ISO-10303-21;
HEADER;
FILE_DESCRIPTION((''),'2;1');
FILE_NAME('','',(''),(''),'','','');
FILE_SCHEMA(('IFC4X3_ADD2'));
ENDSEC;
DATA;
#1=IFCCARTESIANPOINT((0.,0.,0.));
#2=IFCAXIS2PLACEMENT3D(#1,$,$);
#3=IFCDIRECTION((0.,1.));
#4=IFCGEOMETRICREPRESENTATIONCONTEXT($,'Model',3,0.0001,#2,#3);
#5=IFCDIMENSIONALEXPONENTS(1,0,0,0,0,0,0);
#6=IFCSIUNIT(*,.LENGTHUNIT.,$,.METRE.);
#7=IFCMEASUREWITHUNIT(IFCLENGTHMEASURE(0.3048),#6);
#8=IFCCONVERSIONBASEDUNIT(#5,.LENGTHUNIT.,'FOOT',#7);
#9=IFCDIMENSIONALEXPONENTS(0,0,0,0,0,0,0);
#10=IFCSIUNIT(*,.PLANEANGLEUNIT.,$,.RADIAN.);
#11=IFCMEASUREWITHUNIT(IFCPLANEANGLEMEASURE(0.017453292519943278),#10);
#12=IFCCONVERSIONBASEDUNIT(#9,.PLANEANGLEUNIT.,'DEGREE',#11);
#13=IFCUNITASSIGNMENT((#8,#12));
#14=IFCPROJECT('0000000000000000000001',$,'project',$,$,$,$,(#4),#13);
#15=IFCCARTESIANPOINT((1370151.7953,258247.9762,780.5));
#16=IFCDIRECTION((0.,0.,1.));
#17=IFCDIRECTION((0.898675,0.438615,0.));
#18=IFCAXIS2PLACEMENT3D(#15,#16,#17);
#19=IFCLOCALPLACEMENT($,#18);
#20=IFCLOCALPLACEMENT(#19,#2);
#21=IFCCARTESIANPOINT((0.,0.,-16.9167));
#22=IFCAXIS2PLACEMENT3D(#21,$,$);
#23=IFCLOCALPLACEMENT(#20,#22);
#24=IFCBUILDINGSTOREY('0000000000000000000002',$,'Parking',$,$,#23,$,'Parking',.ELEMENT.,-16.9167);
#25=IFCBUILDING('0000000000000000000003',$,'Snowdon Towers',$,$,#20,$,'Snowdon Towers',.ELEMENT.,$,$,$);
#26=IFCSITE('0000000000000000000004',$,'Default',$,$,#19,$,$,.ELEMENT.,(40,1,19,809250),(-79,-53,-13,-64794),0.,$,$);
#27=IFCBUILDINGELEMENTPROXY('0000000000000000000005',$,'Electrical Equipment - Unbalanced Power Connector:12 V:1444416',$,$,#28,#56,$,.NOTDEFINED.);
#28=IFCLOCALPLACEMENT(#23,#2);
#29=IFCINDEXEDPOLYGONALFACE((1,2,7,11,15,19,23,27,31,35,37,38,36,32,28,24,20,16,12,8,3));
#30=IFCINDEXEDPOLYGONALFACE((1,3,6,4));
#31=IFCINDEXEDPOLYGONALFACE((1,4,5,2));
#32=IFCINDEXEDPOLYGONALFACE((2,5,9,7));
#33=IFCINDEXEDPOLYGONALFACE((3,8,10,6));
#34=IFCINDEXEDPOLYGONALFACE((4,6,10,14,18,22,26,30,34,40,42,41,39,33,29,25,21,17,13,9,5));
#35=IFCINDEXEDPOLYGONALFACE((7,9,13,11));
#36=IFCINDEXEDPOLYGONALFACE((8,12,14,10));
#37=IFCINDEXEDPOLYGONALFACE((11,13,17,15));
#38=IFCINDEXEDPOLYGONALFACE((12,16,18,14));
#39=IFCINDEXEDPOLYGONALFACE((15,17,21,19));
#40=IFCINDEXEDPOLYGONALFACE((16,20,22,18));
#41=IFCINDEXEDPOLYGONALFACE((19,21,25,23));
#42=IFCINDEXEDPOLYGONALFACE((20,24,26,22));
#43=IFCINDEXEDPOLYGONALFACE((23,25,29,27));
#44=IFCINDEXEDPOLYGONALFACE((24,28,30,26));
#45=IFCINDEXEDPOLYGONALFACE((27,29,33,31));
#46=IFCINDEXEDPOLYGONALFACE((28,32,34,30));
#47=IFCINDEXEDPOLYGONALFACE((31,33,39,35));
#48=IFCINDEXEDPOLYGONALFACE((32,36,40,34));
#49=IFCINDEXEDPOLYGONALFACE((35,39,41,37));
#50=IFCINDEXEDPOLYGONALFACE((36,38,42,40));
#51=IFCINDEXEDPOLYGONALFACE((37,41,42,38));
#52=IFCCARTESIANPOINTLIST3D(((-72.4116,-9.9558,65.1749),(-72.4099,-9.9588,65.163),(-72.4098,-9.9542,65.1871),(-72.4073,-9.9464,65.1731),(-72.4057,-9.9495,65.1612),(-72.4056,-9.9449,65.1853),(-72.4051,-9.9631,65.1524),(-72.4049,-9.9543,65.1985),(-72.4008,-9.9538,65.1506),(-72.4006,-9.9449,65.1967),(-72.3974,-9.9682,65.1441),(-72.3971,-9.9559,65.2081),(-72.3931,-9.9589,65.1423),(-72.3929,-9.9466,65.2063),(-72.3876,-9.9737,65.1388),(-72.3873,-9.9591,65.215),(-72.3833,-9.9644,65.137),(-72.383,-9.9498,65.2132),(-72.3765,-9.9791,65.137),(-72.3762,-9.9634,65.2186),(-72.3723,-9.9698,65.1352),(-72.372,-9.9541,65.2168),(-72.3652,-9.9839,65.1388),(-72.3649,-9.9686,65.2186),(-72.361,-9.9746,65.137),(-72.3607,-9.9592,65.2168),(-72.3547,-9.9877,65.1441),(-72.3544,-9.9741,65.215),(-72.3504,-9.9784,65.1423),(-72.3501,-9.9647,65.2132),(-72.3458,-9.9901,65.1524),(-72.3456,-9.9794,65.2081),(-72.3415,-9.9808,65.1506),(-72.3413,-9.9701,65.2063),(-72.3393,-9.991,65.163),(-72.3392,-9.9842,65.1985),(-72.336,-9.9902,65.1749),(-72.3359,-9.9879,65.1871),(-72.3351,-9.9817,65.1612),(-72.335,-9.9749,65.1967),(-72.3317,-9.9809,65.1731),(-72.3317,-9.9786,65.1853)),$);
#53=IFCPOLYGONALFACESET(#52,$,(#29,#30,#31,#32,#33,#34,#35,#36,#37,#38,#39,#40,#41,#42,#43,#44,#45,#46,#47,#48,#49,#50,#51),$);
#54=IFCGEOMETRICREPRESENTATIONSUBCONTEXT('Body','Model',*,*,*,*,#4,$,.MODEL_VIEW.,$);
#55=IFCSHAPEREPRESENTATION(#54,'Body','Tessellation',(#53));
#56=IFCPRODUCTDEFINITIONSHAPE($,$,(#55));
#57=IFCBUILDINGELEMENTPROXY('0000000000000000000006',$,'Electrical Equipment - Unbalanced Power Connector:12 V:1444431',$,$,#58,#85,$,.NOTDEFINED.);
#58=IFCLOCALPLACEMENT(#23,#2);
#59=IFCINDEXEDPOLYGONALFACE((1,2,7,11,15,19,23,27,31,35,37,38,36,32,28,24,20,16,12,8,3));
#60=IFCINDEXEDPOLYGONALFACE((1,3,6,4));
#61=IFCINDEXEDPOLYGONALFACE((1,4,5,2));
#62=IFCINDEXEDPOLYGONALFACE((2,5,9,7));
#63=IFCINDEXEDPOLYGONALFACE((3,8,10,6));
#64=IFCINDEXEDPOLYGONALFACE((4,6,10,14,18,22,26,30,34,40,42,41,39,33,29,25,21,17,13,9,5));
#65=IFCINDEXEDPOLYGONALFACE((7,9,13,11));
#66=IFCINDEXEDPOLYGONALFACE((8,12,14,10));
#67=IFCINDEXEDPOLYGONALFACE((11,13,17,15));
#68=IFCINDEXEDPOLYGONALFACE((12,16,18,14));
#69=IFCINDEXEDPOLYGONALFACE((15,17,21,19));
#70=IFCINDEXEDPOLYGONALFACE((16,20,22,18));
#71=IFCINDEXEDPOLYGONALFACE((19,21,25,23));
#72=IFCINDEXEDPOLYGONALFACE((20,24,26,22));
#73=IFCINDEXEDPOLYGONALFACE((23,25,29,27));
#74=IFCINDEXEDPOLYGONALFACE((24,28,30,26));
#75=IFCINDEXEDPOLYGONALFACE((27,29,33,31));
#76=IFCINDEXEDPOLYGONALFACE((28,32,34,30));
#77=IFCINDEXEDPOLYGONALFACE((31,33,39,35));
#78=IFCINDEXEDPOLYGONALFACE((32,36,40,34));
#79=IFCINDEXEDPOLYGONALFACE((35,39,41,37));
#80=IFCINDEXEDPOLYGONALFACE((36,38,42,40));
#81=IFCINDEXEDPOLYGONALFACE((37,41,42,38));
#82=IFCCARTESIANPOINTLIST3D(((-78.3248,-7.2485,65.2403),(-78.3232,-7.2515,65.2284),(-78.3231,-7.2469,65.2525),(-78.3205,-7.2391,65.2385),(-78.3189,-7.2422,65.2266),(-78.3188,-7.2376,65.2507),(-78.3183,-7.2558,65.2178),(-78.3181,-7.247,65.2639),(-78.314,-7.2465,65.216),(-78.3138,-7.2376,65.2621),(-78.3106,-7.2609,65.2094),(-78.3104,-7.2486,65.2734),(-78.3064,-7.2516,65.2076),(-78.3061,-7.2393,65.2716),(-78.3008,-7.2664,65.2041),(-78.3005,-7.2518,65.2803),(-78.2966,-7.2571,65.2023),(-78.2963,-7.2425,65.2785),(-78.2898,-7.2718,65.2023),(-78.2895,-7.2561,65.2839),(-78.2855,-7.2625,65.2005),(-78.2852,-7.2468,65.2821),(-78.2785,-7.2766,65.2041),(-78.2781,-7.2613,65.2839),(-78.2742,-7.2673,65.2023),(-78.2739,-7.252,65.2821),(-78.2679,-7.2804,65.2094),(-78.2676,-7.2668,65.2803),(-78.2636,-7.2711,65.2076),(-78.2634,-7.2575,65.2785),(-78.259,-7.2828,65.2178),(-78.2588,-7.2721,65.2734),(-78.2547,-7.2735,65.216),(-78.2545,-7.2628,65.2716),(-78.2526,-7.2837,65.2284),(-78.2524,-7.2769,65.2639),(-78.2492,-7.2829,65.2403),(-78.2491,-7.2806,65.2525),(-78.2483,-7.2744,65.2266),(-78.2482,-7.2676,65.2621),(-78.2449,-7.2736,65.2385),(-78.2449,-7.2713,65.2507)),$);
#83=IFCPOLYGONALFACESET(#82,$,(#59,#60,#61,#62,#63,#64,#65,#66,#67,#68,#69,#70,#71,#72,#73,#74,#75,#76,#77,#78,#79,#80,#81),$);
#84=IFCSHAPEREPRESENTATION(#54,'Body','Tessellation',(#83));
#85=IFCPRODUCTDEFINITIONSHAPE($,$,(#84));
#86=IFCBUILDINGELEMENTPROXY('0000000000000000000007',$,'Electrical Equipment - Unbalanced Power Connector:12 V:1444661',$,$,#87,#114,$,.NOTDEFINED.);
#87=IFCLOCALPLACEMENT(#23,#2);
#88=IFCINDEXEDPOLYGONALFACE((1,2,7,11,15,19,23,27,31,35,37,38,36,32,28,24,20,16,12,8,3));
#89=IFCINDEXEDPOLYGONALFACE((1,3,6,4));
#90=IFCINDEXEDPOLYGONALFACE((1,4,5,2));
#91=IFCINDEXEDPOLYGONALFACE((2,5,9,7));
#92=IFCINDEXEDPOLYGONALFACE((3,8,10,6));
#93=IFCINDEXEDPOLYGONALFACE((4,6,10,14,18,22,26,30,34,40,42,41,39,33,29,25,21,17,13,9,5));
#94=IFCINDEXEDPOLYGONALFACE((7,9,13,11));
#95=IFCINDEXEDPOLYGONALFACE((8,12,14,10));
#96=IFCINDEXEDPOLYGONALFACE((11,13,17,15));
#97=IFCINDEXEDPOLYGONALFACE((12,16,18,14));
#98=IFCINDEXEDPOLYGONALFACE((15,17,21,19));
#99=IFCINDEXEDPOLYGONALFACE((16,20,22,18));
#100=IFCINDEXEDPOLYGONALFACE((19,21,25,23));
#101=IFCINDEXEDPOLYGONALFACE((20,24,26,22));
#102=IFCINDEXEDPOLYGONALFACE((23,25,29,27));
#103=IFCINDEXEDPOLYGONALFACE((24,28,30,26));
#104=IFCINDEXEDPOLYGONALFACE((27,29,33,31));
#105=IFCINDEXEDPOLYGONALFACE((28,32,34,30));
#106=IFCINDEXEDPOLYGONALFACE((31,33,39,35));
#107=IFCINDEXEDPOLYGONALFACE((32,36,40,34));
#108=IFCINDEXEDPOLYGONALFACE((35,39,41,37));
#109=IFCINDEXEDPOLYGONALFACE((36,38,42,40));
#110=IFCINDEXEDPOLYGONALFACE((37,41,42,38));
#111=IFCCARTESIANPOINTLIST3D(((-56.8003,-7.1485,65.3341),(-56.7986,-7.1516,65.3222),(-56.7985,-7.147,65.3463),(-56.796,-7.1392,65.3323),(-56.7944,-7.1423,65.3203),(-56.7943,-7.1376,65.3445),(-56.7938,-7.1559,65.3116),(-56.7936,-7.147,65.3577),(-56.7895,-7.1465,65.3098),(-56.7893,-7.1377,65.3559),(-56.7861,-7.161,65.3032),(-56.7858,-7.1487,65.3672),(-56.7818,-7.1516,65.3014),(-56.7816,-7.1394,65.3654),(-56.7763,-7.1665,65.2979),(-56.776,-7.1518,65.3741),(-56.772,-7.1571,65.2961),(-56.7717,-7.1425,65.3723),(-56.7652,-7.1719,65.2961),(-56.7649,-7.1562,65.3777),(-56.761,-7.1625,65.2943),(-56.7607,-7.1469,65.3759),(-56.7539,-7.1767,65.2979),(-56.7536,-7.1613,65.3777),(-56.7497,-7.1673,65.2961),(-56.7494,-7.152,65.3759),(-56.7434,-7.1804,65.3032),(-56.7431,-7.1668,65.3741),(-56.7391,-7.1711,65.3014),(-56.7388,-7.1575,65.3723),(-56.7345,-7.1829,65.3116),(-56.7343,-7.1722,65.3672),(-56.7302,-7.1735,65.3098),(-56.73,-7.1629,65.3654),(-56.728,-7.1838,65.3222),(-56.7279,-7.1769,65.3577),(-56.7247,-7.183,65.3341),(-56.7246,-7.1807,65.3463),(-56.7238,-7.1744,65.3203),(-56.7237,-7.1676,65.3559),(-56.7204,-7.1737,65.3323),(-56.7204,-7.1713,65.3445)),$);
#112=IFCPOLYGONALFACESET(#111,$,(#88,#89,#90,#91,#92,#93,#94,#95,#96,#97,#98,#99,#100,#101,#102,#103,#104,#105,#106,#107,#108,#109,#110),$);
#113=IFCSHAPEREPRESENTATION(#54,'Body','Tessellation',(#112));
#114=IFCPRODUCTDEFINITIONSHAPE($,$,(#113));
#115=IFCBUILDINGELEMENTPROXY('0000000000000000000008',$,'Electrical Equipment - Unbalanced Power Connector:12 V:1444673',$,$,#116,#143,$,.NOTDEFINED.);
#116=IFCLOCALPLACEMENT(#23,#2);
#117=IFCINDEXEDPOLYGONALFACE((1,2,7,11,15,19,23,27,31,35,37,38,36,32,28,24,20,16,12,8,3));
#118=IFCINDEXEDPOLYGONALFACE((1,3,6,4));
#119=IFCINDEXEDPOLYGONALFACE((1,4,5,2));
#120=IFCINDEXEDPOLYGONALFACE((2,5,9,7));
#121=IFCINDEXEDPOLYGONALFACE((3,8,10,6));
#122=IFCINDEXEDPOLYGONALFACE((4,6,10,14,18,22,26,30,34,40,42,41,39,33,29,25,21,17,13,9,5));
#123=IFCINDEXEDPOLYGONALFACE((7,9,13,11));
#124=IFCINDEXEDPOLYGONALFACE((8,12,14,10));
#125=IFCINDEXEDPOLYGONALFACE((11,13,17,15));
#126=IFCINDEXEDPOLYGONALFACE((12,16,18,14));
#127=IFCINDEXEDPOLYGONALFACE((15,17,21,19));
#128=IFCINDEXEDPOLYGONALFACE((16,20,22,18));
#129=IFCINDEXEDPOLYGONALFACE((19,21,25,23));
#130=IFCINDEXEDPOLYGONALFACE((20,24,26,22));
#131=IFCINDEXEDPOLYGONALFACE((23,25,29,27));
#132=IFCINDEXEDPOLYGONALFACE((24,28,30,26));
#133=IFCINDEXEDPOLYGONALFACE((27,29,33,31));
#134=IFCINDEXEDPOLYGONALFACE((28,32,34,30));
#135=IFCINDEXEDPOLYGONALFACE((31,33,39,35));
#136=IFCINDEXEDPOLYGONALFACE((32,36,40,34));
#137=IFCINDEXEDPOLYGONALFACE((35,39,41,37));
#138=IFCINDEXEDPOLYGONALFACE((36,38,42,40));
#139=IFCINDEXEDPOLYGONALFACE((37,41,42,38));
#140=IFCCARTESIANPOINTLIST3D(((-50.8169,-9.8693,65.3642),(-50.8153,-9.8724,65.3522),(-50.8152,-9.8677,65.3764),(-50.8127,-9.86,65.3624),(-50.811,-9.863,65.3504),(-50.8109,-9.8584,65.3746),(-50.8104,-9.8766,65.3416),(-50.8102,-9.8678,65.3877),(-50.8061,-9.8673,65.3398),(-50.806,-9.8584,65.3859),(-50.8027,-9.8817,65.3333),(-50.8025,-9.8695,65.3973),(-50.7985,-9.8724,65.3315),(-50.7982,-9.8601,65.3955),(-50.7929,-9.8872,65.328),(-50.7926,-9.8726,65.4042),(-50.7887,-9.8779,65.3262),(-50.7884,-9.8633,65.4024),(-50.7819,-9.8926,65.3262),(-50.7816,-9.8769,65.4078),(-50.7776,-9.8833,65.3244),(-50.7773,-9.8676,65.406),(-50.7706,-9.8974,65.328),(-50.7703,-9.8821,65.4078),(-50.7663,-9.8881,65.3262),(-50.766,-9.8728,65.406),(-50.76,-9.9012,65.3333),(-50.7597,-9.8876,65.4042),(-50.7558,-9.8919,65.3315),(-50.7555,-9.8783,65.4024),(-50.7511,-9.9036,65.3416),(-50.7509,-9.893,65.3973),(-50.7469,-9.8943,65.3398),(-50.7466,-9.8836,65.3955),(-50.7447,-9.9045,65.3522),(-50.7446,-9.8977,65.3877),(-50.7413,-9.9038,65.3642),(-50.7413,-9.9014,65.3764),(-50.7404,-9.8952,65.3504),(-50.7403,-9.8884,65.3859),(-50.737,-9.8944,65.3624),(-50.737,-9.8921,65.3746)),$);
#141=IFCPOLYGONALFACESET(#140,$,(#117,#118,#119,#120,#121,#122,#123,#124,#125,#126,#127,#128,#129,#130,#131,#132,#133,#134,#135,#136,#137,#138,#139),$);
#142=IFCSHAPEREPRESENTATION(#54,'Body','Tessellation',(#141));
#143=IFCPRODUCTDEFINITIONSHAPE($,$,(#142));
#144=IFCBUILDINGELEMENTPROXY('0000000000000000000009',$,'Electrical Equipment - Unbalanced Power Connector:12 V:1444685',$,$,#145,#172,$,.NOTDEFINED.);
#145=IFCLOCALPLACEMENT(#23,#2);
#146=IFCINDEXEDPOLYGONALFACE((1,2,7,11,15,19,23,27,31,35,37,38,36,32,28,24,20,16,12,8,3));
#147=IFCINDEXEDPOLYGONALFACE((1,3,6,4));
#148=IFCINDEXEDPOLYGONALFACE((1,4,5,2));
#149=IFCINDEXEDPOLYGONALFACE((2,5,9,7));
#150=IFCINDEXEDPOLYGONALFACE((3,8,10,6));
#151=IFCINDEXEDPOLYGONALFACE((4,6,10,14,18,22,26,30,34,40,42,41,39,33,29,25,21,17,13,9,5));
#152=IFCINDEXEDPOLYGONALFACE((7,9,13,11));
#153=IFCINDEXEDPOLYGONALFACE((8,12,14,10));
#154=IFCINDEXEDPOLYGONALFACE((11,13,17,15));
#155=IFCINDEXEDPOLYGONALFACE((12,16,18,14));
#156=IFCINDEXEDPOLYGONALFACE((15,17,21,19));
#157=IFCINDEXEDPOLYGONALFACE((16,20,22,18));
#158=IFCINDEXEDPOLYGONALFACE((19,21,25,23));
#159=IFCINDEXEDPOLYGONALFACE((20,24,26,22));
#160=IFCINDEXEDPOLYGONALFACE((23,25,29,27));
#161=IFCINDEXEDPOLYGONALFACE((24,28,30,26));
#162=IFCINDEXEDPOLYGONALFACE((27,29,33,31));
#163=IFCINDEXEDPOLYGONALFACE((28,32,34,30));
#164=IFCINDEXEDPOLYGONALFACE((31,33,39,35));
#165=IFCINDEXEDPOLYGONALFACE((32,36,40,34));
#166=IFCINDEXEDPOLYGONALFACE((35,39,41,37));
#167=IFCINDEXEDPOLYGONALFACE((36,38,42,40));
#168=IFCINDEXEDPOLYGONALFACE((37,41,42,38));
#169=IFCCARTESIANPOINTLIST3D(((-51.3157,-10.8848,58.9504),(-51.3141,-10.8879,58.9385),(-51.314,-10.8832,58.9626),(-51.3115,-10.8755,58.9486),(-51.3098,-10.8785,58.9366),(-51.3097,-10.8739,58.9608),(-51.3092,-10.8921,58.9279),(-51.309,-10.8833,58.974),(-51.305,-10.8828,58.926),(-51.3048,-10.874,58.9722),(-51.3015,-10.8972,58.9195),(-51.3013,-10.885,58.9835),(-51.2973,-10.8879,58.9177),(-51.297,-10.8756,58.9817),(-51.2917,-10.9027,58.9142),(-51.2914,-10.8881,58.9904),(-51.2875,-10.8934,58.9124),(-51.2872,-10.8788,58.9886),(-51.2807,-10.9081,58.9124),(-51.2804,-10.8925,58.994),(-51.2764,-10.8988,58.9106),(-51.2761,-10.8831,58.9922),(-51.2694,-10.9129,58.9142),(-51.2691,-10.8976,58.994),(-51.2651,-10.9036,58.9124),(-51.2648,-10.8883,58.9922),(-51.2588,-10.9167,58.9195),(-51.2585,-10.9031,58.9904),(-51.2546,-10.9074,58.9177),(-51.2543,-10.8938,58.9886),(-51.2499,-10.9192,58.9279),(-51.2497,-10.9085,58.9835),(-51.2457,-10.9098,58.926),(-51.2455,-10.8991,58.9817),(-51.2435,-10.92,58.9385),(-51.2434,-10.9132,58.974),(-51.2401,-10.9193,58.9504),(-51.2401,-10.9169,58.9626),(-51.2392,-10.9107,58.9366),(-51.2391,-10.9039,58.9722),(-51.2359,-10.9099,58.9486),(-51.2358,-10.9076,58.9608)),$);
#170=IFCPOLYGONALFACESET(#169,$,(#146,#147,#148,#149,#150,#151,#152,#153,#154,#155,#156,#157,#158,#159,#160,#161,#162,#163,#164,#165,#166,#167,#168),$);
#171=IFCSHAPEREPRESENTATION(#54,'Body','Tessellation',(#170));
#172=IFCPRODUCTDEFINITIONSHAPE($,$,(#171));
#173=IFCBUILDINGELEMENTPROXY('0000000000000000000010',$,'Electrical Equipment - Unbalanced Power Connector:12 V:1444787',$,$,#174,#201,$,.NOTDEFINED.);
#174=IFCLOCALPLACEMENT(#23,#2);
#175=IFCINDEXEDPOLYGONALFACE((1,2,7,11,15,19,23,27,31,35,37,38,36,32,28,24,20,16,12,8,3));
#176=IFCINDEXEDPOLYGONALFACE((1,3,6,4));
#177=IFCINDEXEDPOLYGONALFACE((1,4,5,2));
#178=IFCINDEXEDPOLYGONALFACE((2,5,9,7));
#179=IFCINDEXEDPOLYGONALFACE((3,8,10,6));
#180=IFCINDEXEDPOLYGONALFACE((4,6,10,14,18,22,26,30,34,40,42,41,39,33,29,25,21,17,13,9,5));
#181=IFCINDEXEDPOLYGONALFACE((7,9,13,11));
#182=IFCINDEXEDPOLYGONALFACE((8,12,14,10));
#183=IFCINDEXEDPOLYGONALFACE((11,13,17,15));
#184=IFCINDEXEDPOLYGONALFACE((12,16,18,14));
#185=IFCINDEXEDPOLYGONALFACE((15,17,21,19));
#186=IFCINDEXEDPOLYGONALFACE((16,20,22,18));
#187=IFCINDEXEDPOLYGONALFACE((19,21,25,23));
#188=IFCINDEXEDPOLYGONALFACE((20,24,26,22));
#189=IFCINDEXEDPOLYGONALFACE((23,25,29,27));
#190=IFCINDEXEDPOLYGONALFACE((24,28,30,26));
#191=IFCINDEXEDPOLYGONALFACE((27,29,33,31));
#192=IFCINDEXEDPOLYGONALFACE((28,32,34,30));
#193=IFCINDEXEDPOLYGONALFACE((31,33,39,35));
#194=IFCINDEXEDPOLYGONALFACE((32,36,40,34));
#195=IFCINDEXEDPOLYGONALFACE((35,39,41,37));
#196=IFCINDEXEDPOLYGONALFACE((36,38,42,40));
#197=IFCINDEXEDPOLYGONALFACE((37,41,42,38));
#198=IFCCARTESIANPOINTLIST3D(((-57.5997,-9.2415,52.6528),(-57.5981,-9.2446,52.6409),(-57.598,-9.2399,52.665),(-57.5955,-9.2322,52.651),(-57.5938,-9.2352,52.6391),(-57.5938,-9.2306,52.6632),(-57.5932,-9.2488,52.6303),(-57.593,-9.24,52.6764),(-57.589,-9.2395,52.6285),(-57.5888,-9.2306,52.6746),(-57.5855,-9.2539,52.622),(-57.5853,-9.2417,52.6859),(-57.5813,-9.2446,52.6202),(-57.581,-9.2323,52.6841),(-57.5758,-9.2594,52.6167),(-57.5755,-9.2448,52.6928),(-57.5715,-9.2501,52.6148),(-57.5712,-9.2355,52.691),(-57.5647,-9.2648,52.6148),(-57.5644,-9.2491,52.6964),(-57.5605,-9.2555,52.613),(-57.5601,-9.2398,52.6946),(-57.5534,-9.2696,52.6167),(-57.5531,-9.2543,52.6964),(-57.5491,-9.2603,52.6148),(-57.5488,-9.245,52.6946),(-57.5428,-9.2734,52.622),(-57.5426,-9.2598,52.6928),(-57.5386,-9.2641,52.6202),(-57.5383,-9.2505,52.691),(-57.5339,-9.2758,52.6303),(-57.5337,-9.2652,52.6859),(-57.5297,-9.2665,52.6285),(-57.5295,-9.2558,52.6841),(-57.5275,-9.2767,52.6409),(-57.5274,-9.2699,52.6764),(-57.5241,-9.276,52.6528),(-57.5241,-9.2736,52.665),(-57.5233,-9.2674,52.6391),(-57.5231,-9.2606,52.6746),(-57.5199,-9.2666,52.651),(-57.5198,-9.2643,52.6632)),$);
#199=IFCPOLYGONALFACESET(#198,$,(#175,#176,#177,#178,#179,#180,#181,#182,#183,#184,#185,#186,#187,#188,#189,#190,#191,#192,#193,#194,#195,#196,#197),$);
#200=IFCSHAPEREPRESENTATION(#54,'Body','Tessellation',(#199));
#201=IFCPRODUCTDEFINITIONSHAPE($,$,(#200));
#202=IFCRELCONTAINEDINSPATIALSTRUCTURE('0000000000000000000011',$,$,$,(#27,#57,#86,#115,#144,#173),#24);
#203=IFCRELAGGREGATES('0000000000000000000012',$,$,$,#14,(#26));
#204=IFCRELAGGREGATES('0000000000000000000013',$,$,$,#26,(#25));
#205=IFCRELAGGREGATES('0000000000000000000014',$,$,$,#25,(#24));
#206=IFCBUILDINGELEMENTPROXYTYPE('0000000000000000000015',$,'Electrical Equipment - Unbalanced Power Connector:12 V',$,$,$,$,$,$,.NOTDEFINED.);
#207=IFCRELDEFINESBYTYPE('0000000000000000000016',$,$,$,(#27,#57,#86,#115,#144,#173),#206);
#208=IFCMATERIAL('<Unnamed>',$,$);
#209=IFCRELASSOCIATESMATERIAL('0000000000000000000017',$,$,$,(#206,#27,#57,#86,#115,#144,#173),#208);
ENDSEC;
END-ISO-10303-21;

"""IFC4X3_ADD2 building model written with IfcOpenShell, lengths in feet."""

from ifc_helpers import new_model, entity, si_unit, converted_unit, direction, frame, frame_2d, origin, place, context, subcontext, project, spatial, circle, extrude, source, transform, mapped, material, type_object, type_shapes, element, save


model = new_model("IFC4X3_ADD2")

# Units and contexts
model_context = context("Model", 3, precision=0.0001, world=origin(), true_north=direction((0.0, 1.0)))
body_context = subcontext(model_context, "Body", "Model", "MODEL_VIEW")
ifc_project = project(units=[converted_unit("LENGTHUNIT", "FOOT", entity("IfcLengthMeasure", 0.3048), si_unit("LENGTHUNIT", "METRE"), dimensions=[1, 0, 0, 0, 0, 0, 0]), converted_unit("PLANEANGLEUNIT", "DEGREE", entity("IfcPlaneAngleMeasure", 0.017453292519943278), si_unit("PLANEANGLEUNIT", "RADIAN"), dimensions=[0, 0, 0, 0, 0, 0, 0])], contexts=[model_context])

# Site, building, storey
site_placement = place(None, frame((1370151.7953, 258247.9762, 780.5), z_axis=(0.0, 0.0, 1.0), x_axis=(0.898675, 0.438615, 0.0)))
site = spatial("IfcSite", under=ifc_project, at=site_placement, Name="Default", CompositionType="ELEMENT", RefLatitude=(40, 1, 19, 809250), RefLongitude=(-79, -53, -13, -64794), RefElevation=0.0)
building_placement = place(site_placement, origin())
building = spatial("IfcBuilding", under=site, at=building_placement, Name="Snowdon Towers", LongName="Snowdon Towers", CompositionType="ELEMENT")
storey_placement = place(building_placement, frame((0.0, 0.0, -16.9167)))
storey = spatial("IfcBuildingStorey", under=building, at=storey_placement, Name="Parking", LongName="Parking", CompositionType="ELEMENT", Elevation=-16.9167)

# Building element proxies
ifc_material_1 = material(Name="<Unnamed>")
building_element_proxy_type = type_object("IfcBuildingElementProxyType", Name="Electrical Equipment - Unbalanced Power Connector:12 V", PredefinedType="NOTDEFINED", material=ifc_material_1)
shared_shape_1 = source(origin(), body_context, "Body", "SweptSolid", [
    extrude(circle(Radius=0.0417, at=frame_2d((0.0, 0.0), x_axis=(1.0, 0.0))), origin(), (0.0, 0.0, 1.0), 0.0104),
])
type_shapes(building_element_proxy_type, [shared_shape_1])
for number, where, z_axis, x_axis, name in (
    (1, (-72.3735, -9.9725, 65.178), (0.408371, 0.896147, -0.173648), (-0.072007, -0.158015, -0.984808), "Electrical Equipment - Unbalanced Power Connector:12 V:1444416"),
    (2, (-78.2868, -7.2652, 65.2434), (0.408371, 0.896147, -0.173648), (-0.072007, -0.158015, -0.984808), "Electrical Equipment - Unbalanced Power Connector:12 V:1444431"),
    (3, (-56.7622, -7.1653, 65.3371), (0.408371, 0.896147, -0.173648), (-0.072007, -0.158015, -0.984808), "Electrical Equipment - Unbalanced Power Connector:12 V:1444661"),
    (4, (-50.7789, -9.886, 65.3672), (0.408371, 0.896147, -0.173648), (-0.072007, -0.158015, -0.984808), "Electrical Equipment - Unbalanced Power Connector:12 V:1444673"),
    (5, (-51.2777, -10.9015, 58.9534), (0.408371, 0.896147, -0.173648), (-0.072007, -0.158015, -0.984808), "Electrical Equipment - Unbalanced Power Connector:12 V:1444685"),
    (6, (-57.5617, -9.2582, 52.6559), (0.408371, 0.896147, -0.173648), (-0.072007, -0.158015, -0.984808), "Electrical Equipment - Unbalanced Power Connector:12 V:1444787"),
):
    element("IfcBuildingElementProxy", number, at=place(storey_placement, frame(where, z_axis=z_axis, x_axis=x_axis)), inside=storey, type_object=building_element_proxy_type, material=ifc_material_1, Name=name, PredefinedType="NOTDEFINED", context=body_context, shape_type="MappedRepresentation", body=[
        mapped(shared_shape_1, transform((0.0, 0.0, 0.0), scale=1.0)),
    ])

save(model, "model.ifc")
